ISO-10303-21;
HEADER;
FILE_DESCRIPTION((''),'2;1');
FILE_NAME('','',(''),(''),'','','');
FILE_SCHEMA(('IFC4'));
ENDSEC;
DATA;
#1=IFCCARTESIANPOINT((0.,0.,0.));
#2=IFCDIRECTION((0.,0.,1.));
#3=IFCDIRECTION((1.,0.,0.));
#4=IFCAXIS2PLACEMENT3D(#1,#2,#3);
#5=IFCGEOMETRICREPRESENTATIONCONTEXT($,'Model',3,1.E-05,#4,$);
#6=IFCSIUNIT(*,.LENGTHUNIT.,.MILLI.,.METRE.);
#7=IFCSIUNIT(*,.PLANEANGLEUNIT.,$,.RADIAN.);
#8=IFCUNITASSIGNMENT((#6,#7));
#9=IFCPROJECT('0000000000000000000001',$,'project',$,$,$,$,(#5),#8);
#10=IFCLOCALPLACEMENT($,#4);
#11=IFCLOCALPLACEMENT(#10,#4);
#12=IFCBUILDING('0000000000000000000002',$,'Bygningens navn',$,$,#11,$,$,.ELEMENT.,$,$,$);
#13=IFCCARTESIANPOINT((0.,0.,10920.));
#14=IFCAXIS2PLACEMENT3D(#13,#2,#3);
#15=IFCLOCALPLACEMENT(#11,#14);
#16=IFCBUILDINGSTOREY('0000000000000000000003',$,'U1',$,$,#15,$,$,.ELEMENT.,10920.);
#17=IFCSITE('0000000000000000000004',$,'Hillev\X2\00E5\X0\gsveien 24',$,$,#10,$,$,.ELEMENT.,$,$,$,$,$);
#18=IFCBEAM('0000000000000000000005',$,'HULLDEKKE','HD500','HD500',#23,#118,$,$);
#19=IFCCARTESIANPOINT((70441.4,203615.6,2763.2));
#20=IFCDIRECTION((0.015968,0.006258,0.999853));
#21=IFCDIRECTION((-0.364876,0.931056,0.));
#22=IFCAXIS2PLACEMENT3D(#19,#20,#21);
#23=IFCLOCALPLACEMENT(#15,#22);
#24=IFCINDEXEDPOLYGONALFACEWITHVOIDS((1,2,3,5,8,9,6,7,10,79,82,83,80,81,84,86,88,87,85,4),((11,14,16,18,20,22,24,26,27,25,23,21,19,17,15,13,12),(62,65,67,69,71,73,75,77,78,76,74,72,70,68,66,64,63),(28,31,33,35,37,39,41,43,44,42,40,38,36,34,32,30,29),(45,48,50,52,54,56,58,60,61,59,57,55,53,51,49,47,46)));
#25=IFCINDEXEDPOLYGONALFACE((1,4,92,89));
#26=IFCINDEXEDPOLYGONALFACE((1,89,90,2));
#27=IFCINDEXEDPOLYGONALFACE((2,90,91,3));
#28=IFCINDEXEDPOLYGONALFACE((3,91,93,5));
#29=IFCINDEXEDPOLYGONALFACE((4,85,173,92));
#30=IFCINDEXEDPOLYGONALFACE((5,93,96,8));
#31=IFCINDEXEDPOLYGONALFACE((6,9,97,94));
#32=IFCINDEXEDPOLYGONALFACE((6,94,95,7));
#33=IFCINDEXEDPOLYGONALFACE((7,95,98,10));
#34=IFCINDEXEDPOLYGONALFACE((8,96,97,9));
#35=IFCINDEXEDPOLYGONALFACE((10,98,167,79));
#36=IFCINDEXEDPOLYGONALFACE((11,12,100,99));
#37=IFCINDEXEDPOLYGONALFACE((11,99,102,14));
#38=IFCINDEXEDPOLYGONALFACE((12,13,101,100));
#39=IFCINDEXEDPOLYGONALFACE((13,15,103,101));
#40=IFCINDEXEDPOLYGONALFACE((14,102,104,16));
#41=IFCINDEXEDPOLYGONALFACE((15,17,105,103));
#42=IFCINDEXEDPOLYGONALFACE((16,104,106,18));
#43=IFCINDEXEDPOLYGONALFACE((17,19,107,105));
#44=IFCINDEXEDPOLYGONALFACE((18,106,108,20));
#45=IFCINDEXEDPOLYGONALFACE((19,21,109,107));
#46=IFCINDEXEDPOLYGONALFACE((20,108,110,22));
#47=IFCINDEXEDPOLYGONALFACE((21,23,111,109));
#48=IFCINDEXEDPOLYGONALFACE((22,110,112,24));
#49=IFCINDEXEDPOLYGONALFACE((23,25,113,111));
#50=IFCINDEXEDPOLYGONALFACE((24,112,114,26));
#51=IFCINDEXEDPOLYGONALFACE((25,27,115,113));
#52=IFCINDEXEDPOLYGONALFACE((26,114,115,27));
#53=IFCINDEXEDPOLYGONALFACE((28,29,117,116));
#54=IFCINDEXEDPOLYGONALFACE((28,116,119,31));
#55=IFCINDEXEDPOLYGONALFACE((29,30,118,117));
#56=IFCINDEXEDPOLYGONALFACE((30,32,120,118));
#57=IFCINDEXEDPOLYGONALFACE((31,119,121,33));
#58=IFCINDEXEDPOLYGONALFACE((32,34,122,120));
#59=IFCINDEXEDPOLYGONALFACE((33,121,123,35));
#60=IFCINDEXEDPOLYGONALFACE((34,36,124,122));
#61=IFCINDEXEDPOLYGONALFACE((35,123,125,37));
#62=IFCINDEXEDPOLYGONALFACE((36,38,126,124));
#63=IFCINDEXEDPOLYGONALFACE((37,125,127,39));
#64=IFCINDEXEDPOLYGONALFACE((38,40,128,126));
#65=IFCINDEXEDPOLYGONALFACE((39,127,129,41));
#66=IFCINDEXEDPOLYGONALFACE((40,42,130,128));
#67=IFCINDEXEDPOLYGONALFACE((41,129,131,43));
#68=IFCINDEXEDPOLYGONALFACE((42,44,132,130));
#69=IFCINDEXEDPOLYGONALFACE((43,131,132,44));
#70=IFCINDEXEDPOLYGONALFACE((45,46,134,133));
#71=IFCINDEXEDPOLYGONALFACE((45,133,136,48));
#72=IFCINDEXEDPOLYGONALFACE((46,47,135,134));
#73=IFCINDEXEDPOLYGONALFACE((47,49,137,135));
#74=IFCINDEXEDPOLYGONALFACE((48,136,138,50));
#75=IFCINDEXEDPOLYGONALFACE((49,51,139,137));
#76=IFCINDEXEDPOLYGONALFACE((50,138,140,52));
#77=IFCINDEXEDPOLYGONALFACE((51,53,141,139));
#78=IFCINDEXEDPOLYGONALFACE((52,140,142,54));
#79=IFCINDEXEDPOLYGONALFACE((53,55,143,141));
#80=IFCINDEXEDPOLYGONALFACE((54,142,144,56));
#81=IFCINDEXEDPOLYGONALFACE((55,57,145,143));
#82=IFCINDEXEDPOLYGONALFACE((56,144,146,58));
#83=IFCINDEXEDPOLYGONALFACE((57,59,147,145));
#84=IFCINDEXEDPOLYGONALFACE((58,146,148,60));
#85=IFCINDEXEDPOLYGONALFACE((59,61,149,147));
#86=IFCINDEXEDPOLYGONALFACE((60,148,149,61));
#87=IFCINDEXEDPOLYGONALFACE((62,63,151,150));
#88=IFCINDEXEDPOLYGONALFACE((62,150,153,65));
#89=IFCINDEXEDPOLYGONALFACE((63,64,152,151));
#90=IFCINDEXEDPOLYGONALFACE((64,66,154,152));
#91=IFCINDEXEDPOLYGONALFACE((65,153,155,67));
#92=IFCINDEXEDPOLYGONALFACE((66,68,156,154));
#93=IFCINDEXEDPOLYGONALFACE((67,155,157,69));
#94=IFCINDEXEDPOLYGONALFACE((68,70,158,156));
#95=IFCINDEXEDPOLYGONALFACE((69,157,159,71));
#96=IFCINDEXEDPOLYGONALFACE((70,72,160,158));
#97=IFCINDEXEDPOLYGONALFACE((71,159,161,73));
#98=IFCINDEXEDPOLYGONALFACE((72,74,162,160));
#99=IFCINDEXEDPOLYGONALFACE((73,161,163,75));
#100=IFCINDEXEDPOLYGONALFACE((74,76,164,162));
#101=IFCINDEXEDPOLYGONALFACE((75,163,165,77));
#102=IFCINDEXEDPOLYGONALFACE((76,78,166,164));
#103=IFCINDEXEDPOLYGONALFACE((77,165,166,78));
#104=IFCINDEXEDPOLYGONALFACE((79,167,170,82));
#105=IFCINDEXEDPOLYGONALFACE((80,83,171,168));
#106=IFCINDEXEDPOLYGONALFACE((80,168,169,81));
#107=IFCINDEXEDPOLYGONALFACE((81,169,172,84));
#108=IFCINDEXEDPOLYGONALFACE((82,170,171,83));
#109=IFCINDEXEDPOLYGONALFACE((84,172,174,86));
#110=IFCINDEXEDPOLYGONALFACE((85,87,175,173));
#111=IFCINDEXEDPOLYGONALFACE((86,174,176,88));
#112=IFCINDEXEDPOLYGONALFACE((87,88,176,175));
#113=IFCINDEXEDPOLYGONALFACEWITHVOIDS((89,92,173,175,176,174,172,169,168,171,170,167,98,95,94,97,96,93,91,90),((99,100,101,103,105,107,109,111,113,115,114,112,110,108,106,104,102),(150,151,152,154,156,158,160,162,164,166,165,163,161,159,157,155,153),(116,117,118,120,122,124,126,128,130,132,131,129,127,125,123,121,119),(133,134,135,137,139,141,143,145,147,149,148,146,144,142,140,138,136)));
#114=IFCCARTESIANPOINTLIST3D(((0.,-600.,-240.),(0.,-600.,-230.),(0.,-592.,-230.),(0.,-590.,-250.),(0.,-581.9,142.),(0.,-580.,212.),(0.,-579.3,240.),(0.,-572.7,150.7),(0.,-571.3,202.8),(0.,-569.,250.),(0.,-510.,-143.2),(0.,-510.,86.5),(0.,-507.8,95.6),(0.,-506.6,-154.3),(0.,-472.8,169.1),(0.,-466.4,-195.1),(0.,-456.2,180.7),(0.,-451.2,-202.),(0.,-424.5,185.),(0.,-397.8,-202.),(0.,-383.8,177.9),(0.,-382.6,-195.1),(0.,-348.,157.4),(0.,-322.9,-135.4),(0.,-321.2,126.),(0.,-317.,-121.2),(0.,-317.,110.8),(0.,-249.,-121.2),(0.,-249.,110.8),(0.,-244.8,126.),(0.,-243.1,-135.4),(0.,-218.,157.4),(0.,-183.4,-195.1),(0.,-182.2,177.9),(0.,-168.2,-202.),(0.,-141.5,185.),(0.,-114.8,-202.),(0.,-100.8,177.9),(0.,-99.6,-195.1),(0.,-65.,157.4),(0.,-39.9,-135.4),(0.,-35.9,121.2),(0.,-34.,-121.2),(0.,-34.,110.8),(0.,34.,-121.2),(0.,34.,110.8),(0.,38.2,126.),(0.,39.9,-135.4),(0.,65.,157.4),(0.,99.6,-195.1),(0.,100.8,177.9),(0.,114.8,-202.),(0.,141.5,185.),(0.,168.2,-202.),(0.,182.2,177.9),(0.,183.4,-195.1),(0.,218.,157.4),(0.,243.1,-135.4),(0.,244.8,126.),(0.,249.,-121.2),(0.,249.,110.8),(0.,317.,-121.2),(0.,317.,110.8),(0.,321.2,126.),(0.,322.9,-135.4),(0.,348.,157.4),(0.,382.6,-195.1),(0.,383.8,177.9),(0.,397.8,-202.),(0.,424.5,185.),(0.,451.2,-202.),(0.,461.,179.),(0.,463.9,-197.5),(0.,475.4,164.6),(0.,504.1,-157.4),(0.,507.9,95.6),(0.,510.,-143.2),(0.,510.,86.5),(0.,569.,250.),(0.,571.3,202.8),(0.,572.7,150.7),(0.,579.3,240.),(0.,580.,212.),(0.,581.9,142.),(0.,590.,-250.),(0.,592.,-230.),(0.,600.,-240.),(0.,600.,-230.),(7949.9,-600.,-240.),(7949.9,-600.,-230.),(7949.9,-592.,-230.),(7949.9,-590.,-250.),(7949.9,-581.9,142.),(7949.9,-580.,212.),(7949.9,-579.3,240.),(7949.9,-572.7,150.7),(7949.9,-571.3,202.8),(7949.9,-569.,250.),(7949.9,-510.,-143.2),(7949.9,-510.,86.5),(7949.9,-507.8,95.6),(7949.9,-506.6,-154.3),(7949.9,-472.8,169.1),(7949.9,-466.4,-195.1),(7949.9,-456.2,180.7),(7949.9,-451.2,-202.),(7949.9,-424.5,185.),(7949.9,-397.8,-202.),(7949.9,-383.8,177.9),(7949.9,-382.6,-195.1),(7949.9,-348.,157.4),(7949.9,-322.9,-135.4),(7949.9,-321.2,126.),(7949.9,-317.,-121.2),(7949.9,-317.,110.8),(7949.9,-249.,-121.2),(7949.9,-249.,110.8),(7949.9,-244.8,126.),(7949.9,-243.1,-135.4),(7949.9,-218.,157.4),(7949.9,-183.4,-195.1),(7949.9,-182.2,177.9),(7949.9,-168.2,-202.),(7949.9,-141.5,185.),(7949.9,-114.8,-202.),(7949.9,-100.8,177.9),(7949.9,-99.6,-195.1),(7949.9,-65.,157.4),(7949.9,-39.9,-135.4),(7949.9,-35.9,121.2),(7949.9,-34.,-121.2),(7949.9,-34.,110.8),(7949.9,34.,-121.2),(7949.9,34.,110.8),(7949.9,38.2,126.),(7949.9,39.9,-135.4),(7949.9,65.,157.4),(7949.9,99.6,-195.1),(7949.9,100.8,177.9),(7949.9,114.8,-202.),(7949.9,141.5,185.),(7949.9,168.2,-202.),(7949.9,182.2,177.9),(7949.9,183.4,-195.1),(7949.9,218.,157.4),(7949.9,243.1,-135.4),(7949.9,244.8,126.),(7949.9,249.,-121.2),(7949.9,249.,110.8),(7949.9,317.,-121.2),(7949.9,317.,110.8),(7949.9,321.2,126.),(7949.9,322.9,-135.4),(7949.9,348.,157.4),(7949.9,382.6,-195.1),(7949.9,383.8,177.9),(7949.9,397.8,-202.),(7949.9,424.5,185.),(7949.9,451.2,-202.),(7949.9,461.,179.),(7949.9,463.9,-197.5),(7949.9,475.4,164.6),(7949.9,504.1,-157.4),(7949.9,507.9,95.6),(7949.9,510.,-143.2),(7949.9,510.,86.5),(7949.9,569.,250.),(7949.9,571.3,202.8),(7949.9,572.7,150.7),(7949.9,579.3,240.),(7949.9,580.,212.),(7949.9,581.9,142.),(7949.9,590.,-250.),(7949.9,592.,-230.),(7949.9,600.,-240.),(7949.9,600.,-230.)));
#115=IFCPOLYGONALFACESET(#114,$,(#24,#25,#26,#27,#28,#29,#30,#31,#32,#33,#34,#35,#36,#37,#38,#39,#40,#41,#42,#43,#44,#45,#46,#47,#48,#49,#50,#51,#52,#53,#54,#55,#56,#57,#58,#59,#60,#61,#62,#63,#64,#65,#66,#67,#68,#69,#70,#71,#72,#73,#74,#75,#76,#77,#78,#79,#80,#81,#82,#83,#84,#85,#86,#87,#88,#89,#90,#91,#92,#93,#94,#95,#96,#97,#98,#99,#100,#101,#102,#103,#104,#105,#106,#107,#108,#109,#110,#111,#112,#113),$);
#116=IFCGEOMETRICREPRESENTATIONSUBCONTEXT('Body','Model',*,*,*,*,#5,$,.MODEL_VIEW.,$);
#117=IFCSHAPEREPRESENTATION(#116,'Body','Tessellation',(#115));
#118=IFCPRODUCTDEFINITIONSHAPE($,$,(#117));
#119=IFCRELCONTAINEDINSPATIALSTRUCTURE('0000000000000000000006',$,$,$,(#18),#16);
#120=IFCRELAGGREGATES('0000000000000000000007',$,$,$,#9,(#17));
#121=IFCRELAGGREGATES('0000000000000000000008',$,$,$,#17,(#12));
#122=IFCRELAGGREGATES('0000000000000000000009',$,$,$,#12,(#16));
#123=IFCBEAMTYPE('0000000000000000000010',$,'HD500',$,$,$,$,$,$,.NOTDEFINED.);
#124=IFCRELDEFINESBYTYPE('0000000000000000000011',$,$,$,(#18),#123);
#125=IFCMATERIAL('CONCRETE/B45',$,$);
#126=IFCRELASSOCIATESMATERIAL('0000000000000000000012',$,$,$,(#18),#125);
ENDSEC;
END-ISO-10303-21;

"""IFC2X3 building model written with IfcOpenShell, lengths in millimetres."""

from ifc_helpers import new_model, si_unit, frame, origin_with_axes, place, context, subcontext, project, spatial, polyline, outline, extrude, material, type_object, element, save


model = new_model("IFC2X3")

# Units and contexts
model_context = context("Model", 3, precision=1e-05, world=origin_with_axes())
body_context = subcontext(model_context, "Body", "Model", "MODEL_VIEW")
ifc_project = project(units=[si_unit("LENGTHUNIT", "METRE", prefix="MILLI"), si_unit("PLANEANGLEUNIT", "RADIAN")], contexts=[model_context])

# Site, building, storey
site_placement = place(None, origin_with_axes())
site = spatial("IfcSite", under=ifc_project, at=site_placement, Name="Hillevågsveien 24", CompositionType="ELEMENT")
building_placement = place(site_placement, origin_with_axes())
building = spatial("IfcBuilding", under=site, at=building_placement, Name="Bygningens navn", CompositionType="ELEMENT")
storey_placement = place(building_placement, frame((0.0, 0.0, 10920.0), z_axis=(0.0, 0.0, 1.0), x_axis=(1.0, 0.0, 0.0)))
storey = spatial("IfcBuildingStorey", under=building, at=storey_placement, Name="U1", CompositionType="ELEMENT", Elevation=10920.0)

# Beam
ifc_material_1 = material(Name="CONCRETE/B45")
beam_type_1 = type_object("IfcBeamType", Name="HD500", PredefinedType="NOTDEFINED")
beam_1_placement = place(storey_placement, frame((70441.4, 203615.6, 2763.2), z_axis=(0.015968, 0.006258, 0.999853), x_axis=(-0.364876, 0.931056, 0.0)))
element("IfcBeam", 1, at=beam_1_placement, inside=storey, type_object=beam_type_1, material=ifc_material_1, Name="HULLDEKKE", Description="HD500", ObjectType="HD500", context=body_context, shape_type="SweptSolid", body=[
    extrude(outline(polyline([(581.9, 142.0), (592.0, -230.0), (600.0, -230.0), (600.0, -240.0), (590.0, -250.0), (-590.0, -250.0), (-600.0, -240.0), (-600.0, -230.0), (-592.0, -230.0), (-581.9, 142.0), (-572.7, 150.7), (-571.3, 202.8), (-580.0, 212.0), (-579.3, 240.0), (-569.0, 250.0), (569.0, 250.0), (579.3, 240.0), (580.0, 212.0), (571.3, 202.8), (572.7, 150.7), (581.9, 142.0)]), holes=[polyline([(466.4, -195.1), (506.6, -154.3), (510.0, -143.2), (510.0, 86.5), (507.8, 95.6), (472.8, 169.1), (456.2, 180.7), (424.5, 185.0), (383.8, 177.9), (348.0, 157.4), (321.2, 126.0), (317.0, 110.8), (317.0, -121.2), (322.9, -135.4), (382.6, -195.1), (397.8, -202.0), (451.2, -202.0), (466.4, -195.1)]), polyline([(183.4, -195.1), (243.1, -135.4), (249.0, -121.2), (249.0, 110.8), (244.8, 126.0), (218.0, 157.4), (182.2, 177.9), (141.5, 185.0), (100.8, 177.9), (65.0, 157.4), (35.9, 121.2), (34.0, 110.8), (34.0, -121.2), (39.9, -135.4), (99.6, -195.1), (114.8, -202.0), (168.2, -202.0), (183.4, -195.1)]), polyline([(-99.6, -195.1), (-39.9, -135.4), (-34.0, -121.2), (-34.0, 110.8), (-38.2, 126.0), (-65.0, 157.4), (-100.8, 177.9), (-141.5, 185.0), (-182.2, 177.9), (-218.0, 157.4), (-244.8, 126.0), (-249.0, 110.8), (-249.0, -121.2), (-243.1, -135.4), (-183.4, -195.1), (-168.2, -202.0), (-114.8, -202.0), (-99.6, -195.1)]), polyline([(-382.6, -195.1), (-322.9, -135.4), (-317.0, -121.2), (-317.0, 110.8), (-321.2, 126.0), (-348.0, 157.4), (-383.8, 177.9), (-424.5, 185.0), (-461.0, 179.0), (-475.4, 164.6), (-507.9, 95.6), (-510.0, 86.5), (-510.0, -143.2), (-504.1, -157.4), (-463.9, -197.5), (-451.2, -202.0), (-397.8, -202.0), (-382.6, -195.1)])]), frame((7949.9, 0.0, 0.0), z_axis=(-1.0, 0.0, 0.0), x_axis=(0.0, -1.0, 0.0)), (0.0, 0.0, 1.0), 7949.9),
])

save(model, "model.ifc")
